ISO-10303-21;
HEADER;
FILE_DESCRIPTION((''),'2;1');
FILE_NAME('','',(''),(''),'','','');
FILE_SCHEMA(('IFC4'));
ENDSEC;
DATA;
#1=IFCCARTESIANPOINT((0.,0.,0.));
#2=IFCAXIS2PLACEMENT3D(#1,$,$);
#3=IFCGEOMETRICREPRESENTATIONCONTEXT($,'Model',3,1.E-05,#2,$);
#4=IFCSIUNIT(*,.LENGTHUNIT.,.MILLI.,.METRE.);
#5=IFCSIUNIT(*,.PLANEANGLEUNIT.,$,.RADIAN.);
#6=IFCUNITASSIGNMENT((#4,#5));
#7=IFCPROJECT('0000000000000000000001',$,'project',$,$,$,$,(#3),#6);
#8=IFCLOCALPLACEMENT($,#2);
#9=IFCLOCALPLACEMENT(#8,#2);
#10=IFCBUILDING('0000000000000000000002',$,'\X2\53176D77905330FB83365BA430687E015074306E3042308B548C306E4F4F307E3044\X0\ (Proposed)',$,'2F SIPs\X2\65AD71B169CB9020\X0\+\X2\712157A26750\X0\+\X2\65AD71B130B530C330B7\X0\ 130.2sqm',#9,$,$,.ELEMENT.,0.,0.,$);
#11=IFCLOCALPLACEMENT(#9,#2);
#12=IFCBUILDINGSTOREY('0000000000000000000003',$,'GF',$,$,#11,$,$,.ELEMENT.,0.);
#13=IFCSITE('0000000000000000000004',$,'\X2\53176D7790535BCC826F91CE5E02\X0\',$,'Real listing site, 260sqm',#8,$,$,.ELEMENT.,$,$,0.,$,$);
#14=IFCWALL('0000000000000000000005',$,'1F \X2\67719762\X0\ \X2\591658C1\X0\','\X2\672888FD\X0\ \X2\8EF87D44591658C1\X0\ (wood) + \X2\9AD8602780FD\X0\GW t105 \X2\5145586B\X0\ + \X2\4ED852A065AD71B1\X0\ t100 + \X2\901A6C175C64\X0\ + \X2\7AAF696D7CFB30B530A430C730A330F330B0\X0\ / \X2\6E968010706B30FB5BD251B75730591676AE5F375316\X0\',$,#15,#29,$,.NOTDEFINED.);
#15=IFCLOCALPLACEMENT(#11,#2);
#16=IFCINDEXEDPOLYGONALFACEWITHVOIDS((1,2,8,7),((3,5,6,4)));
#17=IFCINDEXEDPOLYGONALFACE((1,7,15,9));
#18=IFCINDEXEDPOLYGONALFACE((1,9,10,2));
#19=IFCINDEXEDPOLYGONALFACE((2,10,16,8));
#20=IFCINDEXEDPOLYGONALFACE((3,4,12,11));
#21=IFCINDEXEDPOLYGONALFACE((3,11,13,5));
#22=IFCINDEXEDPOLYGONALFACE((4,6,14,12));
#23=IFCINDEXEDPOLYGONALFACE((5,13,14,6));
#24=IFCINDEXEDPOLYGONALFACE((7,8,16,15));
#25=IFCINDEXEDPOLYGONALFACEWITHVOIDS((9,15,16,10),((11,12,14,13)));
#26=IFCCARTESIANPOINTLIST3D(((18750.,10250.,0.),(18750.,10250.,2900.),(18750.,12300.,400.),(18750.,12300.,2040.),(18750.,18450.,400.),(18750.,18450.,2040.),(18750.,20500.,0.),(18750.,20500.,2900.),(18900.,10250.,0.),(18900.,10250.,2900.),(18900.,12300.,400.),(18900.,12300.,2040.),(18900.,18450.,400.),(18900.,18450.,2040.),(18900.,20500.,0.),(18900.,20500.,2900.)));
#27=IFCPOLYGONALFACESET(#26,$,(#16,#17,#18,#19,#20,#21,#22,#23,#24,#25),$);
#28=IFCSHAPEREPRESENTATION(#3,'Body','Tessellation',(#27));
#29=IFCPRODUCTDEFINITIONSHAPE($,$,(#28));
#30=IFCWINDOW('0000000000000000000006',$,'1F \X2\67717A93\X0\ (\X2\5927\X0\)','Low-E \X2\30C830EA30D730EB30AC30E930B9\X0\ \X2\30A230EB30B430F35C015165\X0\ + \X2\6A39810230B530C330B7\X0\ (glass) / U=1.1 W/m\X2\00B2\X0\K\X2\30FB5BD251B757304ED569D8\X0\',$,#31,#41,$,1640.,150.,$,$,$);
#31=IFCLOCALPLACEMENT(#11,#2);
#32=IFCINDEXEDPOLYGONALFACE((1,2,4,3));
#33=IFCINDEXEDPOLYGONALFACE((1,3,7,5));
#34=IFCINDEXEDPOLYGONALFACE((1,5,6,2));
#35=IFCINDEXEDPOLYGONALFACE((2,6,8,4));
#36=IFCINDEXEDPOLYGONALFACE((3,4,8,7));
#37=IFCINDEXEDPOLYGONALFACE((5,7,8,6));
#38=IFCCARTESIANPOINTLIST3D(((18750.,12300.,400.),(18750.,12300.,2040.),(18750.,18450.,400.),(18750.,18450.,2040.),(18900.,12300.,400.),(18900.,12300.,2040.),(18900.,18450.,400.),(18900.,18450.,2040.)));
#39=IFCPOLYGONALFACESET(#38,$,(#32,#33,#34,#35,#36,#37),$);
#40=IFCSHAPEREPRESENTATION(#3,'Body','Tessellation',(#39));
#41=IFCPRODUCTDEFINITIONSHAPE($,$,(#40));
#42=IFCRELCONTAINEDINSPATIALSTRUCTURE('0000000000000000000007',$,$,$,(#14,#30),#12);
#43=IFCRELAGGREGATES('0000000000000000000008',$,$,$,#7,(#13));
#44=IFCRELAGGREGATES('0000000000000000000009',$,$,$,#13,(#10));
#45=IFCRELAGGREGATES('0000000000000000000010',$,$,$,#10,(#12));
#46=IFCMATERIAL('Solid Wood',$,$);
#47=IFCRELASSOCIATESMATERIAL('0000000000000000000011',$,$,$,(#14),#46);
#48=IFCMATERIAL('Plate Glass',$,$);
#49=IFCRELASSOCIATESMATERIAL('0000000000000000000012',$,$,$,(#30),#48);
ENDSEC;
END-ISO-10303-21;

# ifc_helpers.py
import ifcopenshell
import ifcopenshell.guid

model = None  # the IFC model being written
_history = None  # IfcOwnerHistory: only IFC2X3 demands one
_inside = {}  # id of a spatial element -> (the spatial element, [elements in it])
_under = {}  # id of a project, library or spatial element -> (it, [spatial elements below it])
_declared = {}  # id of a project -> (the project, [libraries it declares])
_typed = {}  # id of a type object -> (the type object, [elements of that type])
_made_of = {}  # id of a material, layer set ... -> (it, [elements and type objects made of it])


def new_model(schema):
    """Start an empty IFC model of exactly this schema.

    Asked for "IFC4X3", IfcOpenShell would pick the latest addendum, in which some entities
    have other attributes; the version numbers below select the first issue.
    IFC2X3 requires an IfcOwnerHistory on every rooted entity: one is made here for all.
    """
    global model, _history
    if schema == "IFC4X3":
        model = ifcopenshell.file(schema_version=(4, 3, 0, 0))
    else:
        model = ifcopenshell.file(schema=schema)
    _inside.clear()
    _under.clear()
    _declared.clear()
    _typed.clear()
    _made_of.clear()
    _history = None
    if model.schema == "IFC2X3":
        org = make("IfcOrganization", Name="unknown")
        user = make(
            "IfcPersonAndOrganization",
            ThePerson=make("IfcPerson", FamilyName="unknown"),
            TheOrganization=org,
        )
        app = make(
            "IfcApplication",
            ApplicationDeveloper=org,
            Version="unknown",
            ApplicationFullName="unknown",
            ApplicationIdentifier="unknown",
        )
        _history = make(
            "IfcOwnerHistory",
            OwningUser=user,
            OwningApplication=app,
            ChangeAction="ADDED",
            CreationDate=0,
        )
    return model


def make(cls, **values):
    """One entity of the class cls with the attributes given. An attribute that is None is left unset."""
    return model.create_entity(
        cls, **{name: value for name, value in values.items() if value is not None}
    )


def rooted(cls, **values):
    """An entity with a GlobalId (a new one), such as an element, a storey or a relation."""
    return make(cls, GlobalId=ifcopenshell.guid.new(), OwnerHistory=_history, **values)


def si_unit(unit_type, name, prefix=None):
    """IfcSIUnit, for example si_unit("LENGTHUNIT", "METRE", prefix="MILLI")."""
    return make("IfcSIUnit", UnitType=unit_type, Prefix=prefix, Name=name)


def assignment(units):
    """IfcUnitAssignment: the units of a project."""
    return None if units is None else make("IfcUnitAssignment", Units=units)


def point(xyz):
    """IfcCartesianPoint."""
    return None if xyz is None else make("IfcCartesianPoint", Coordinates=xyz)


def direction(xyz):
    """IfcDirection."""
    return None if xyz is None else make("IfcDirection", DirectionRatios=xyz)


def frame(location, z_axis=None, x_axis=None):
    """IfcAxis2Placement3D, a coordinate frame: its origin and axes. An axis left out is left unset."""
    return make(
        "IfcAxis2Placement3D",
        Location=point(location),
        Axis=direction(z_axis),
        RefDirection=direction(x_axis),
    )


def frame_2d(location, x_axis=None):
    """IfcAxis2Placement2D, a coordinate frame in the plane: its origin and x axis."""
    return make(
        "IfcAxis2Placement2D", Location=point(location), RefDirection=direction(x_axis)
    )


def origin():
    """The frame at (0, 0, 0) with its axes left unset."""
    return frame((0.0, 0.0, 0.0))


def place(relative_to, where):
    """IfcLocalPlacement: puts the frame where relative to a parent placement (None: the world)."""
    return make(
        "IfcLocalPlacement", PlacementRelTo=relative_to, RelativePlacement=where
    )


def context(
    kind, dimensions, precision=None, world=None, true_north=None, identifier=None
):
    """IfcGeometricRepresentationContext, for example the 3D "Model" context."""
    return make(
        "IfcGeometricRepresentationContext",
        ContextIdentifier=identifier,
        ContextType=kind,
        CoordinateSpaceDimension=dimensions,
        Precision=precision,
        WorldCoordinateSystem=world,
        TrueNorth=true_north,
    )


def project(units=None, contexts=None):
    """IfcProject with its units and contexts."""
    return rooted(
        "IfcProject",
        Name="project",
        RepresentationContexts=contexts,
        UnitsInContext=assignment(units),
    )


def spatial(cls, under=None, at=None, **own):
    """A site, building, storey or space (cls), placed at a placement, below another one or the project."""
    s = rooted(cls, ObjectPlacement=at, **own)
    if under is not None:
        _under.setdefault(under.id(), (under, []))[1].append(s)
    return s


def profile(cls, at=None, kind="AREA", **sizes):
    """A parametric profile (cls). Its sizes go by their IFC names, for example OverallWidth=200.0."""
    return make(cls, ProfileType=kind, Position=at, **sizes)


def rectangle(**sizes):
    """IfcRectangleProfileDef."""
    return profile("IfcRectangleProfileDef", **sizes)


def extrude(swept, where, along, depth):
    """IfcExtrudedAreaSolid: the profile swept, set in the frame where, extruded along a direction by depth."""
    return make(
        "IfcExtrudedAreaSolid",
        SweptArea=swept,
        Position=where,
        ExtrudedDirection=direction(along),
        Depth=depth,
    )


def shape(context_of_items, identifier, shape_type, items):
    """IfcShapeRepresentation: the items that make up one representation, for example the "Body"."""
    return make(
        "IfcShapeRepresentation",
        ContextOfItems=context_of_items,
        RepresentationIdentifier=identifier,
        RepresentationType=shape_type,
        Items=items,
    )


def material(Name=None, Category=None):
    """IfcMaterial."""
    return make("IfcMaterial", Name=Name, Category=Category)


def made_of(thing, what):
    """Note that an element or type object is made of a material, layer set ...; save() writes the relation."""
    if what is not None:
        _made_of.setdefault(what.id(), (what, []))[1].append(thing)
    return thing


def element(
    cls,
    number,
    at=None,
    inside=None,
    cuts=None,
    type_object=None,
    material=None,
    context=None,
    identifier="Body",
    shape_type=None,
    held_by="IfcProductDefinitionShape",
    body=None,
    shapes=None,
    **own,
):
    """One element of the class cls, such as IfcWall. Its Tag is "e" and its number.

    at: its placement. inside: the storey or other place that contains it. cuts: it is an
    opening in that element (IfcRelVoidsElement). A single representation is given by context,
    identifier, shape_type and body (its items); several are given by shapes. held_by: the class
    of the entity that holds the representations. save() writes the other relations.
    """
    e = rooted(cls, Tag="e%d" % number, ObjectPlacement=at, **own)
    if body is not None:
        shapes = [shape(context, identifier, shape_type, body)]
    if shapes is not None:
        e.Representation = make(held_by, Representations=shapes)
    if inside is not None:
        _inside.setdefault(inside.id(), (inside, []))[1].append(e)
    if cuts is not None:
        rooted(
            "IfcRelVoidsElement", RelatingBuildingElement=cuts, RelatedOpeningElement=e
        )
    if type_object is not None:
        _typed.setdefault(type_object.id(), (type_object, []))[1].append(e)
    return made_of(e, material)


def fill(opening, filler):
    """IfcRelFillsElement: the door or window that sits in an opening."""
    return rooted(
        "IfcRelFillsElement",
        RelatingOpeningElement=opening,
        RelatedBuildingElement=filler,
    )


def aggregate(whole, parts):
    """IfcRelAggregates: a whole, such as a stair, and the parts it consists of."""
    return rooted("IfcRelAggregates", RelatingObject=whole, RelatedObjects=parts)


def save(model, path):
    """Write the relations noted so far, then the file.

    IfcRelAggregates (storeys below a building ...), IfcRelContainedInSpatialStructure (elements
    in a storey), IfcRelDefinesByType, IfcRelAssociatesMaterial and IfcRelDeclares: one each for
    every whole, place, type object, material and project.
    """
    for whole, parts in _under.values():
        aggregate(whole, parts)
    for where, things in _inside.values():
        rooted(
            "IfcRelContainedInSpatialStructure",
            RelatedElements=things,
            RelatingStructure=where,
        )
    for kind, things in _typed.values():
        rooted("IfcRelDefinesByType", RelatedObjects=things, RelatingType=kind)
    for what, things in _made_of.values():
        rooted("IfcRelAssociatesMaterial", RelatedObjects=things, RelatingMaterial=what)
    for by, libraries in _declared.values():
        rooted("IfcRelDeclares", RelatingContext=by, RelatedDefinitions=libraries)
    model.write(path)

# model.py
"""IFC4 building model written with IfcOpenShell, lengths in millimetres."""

from ifc_helpers import new_model, si_unit, frame, frame_2d, origin, place, context, project, spatial, rectangle, extrude, material, element, fill, save


model = new_model("IFC4")

# Units and contexts
model_context = context("Model", 3, precision=1e-05, world=origin())
ifc_project = project(units=[si_unit("LENGTHUNIT", "METRE", prefix="MILLI"), si_unit("PLANEANGLEUNIT", "RADIAN")], contexts=[model_context])

# Site, building, storey
site_placement = place(None, origin())
site = spatial("IfcSite", under=ifc_project, at=site_placement, Name="北海道富良野市", ObjectType="Real listing site, 260sqm", CompositionType="ELEMENT", RefElevation=0.0)
building_placement = place(site_placement, origin())
building = spatial("IfcBuilding", under=site, at=building_placement, Name="北海道・茶室と縁側のある和の住まい (Proposed)", ObjectType="2F SIPs断熱構造+無垢材+断熱サッシ 130.2sqm", CompositionType="ELEMENT", ElevationOfRefHeight=0.0, ElevationOfTerrain=0.0)
storey_placement = place(building_placement, origin())
storey = spatial("IfcBuildingStorey", under=building, at=storey_placement, Name="GF", CompositionType="ELEMENT", Elevation=0.0)

# Shared definitions
ifc_material_1 = material(Name="Solid Wood")

# Wall, opening, window
wall_1_placement = place(storey_placement, frame((9375.0, 5125.0, 0.0)))
wall_1 = element("IfcWall", 1, at=wall_1_placement, inside=storey, material=ifc_material_1, Name="1F 東面 外壁", Description="木製 軸組外壁 (wood) + 高性能GW t105 充填 + 付加断熱 t100 + 通気層 + 窯業系サイディング / 準耐火・寒冷地外皮強化", PredefinedType="NOTDEFINED", context=model_context, shape_type="SweptSolid", body=[
    extrude(rectangle(XDim=150.0, YDim=10250.0, at=frame_2d((75.0, 5125.0))), frame((9375.0, 5125.0, 0.0)), (0.0, 0.0, 1.0), 2900.0),
])
opening_1_placement = place(storey_placement, frame((9375.0, 6150.0, 200.0)))
opening_1 = element("IfcOpeningElement", 2, at=opening_1_placement, cuts=wall_1, PredefinedType="NOTDEFINED", context=model_context, shape_type="SweptSolid", body=[
    extrude(rectangle(XDim=150.0, YDim=6150.0, at=frame_2d((75.0, 3075.0))), frame((9375.0, 6150.0, 200.0)), (0.0, 0.0, 1.0), 1640.0),
])
ifc_material_2 = material(Name="Plate Glass")
window_1_placement = place(storey_placement, frame((9375.0, 6150.0, 200.0)))
window_1 = element("IfcWindow", 3, at=window_1_placement, inside=storey, material=ifc_material_2, Name="1F 東窓 (大)", Description="Low-E トリプルガラス アルゴン封入 + 樹脂サッシ (glass) / U=1.1 W/m²K・寒冷地仕様", OverallHeight=1640.0, OverallWidth=150.0, context=model_context, shape_type="SweptSolid", body=[
    extrude(rectangle(XDim=150.0, YDim=6150.0, at=frame_2d((75.0, 3075.0))), frame((9375.0, 6150.0, 200.0)), (0.0, 0.0, 1.0), 1640.0),
])
fill(opening_1, window_1)

save(model, "model.ifc")
